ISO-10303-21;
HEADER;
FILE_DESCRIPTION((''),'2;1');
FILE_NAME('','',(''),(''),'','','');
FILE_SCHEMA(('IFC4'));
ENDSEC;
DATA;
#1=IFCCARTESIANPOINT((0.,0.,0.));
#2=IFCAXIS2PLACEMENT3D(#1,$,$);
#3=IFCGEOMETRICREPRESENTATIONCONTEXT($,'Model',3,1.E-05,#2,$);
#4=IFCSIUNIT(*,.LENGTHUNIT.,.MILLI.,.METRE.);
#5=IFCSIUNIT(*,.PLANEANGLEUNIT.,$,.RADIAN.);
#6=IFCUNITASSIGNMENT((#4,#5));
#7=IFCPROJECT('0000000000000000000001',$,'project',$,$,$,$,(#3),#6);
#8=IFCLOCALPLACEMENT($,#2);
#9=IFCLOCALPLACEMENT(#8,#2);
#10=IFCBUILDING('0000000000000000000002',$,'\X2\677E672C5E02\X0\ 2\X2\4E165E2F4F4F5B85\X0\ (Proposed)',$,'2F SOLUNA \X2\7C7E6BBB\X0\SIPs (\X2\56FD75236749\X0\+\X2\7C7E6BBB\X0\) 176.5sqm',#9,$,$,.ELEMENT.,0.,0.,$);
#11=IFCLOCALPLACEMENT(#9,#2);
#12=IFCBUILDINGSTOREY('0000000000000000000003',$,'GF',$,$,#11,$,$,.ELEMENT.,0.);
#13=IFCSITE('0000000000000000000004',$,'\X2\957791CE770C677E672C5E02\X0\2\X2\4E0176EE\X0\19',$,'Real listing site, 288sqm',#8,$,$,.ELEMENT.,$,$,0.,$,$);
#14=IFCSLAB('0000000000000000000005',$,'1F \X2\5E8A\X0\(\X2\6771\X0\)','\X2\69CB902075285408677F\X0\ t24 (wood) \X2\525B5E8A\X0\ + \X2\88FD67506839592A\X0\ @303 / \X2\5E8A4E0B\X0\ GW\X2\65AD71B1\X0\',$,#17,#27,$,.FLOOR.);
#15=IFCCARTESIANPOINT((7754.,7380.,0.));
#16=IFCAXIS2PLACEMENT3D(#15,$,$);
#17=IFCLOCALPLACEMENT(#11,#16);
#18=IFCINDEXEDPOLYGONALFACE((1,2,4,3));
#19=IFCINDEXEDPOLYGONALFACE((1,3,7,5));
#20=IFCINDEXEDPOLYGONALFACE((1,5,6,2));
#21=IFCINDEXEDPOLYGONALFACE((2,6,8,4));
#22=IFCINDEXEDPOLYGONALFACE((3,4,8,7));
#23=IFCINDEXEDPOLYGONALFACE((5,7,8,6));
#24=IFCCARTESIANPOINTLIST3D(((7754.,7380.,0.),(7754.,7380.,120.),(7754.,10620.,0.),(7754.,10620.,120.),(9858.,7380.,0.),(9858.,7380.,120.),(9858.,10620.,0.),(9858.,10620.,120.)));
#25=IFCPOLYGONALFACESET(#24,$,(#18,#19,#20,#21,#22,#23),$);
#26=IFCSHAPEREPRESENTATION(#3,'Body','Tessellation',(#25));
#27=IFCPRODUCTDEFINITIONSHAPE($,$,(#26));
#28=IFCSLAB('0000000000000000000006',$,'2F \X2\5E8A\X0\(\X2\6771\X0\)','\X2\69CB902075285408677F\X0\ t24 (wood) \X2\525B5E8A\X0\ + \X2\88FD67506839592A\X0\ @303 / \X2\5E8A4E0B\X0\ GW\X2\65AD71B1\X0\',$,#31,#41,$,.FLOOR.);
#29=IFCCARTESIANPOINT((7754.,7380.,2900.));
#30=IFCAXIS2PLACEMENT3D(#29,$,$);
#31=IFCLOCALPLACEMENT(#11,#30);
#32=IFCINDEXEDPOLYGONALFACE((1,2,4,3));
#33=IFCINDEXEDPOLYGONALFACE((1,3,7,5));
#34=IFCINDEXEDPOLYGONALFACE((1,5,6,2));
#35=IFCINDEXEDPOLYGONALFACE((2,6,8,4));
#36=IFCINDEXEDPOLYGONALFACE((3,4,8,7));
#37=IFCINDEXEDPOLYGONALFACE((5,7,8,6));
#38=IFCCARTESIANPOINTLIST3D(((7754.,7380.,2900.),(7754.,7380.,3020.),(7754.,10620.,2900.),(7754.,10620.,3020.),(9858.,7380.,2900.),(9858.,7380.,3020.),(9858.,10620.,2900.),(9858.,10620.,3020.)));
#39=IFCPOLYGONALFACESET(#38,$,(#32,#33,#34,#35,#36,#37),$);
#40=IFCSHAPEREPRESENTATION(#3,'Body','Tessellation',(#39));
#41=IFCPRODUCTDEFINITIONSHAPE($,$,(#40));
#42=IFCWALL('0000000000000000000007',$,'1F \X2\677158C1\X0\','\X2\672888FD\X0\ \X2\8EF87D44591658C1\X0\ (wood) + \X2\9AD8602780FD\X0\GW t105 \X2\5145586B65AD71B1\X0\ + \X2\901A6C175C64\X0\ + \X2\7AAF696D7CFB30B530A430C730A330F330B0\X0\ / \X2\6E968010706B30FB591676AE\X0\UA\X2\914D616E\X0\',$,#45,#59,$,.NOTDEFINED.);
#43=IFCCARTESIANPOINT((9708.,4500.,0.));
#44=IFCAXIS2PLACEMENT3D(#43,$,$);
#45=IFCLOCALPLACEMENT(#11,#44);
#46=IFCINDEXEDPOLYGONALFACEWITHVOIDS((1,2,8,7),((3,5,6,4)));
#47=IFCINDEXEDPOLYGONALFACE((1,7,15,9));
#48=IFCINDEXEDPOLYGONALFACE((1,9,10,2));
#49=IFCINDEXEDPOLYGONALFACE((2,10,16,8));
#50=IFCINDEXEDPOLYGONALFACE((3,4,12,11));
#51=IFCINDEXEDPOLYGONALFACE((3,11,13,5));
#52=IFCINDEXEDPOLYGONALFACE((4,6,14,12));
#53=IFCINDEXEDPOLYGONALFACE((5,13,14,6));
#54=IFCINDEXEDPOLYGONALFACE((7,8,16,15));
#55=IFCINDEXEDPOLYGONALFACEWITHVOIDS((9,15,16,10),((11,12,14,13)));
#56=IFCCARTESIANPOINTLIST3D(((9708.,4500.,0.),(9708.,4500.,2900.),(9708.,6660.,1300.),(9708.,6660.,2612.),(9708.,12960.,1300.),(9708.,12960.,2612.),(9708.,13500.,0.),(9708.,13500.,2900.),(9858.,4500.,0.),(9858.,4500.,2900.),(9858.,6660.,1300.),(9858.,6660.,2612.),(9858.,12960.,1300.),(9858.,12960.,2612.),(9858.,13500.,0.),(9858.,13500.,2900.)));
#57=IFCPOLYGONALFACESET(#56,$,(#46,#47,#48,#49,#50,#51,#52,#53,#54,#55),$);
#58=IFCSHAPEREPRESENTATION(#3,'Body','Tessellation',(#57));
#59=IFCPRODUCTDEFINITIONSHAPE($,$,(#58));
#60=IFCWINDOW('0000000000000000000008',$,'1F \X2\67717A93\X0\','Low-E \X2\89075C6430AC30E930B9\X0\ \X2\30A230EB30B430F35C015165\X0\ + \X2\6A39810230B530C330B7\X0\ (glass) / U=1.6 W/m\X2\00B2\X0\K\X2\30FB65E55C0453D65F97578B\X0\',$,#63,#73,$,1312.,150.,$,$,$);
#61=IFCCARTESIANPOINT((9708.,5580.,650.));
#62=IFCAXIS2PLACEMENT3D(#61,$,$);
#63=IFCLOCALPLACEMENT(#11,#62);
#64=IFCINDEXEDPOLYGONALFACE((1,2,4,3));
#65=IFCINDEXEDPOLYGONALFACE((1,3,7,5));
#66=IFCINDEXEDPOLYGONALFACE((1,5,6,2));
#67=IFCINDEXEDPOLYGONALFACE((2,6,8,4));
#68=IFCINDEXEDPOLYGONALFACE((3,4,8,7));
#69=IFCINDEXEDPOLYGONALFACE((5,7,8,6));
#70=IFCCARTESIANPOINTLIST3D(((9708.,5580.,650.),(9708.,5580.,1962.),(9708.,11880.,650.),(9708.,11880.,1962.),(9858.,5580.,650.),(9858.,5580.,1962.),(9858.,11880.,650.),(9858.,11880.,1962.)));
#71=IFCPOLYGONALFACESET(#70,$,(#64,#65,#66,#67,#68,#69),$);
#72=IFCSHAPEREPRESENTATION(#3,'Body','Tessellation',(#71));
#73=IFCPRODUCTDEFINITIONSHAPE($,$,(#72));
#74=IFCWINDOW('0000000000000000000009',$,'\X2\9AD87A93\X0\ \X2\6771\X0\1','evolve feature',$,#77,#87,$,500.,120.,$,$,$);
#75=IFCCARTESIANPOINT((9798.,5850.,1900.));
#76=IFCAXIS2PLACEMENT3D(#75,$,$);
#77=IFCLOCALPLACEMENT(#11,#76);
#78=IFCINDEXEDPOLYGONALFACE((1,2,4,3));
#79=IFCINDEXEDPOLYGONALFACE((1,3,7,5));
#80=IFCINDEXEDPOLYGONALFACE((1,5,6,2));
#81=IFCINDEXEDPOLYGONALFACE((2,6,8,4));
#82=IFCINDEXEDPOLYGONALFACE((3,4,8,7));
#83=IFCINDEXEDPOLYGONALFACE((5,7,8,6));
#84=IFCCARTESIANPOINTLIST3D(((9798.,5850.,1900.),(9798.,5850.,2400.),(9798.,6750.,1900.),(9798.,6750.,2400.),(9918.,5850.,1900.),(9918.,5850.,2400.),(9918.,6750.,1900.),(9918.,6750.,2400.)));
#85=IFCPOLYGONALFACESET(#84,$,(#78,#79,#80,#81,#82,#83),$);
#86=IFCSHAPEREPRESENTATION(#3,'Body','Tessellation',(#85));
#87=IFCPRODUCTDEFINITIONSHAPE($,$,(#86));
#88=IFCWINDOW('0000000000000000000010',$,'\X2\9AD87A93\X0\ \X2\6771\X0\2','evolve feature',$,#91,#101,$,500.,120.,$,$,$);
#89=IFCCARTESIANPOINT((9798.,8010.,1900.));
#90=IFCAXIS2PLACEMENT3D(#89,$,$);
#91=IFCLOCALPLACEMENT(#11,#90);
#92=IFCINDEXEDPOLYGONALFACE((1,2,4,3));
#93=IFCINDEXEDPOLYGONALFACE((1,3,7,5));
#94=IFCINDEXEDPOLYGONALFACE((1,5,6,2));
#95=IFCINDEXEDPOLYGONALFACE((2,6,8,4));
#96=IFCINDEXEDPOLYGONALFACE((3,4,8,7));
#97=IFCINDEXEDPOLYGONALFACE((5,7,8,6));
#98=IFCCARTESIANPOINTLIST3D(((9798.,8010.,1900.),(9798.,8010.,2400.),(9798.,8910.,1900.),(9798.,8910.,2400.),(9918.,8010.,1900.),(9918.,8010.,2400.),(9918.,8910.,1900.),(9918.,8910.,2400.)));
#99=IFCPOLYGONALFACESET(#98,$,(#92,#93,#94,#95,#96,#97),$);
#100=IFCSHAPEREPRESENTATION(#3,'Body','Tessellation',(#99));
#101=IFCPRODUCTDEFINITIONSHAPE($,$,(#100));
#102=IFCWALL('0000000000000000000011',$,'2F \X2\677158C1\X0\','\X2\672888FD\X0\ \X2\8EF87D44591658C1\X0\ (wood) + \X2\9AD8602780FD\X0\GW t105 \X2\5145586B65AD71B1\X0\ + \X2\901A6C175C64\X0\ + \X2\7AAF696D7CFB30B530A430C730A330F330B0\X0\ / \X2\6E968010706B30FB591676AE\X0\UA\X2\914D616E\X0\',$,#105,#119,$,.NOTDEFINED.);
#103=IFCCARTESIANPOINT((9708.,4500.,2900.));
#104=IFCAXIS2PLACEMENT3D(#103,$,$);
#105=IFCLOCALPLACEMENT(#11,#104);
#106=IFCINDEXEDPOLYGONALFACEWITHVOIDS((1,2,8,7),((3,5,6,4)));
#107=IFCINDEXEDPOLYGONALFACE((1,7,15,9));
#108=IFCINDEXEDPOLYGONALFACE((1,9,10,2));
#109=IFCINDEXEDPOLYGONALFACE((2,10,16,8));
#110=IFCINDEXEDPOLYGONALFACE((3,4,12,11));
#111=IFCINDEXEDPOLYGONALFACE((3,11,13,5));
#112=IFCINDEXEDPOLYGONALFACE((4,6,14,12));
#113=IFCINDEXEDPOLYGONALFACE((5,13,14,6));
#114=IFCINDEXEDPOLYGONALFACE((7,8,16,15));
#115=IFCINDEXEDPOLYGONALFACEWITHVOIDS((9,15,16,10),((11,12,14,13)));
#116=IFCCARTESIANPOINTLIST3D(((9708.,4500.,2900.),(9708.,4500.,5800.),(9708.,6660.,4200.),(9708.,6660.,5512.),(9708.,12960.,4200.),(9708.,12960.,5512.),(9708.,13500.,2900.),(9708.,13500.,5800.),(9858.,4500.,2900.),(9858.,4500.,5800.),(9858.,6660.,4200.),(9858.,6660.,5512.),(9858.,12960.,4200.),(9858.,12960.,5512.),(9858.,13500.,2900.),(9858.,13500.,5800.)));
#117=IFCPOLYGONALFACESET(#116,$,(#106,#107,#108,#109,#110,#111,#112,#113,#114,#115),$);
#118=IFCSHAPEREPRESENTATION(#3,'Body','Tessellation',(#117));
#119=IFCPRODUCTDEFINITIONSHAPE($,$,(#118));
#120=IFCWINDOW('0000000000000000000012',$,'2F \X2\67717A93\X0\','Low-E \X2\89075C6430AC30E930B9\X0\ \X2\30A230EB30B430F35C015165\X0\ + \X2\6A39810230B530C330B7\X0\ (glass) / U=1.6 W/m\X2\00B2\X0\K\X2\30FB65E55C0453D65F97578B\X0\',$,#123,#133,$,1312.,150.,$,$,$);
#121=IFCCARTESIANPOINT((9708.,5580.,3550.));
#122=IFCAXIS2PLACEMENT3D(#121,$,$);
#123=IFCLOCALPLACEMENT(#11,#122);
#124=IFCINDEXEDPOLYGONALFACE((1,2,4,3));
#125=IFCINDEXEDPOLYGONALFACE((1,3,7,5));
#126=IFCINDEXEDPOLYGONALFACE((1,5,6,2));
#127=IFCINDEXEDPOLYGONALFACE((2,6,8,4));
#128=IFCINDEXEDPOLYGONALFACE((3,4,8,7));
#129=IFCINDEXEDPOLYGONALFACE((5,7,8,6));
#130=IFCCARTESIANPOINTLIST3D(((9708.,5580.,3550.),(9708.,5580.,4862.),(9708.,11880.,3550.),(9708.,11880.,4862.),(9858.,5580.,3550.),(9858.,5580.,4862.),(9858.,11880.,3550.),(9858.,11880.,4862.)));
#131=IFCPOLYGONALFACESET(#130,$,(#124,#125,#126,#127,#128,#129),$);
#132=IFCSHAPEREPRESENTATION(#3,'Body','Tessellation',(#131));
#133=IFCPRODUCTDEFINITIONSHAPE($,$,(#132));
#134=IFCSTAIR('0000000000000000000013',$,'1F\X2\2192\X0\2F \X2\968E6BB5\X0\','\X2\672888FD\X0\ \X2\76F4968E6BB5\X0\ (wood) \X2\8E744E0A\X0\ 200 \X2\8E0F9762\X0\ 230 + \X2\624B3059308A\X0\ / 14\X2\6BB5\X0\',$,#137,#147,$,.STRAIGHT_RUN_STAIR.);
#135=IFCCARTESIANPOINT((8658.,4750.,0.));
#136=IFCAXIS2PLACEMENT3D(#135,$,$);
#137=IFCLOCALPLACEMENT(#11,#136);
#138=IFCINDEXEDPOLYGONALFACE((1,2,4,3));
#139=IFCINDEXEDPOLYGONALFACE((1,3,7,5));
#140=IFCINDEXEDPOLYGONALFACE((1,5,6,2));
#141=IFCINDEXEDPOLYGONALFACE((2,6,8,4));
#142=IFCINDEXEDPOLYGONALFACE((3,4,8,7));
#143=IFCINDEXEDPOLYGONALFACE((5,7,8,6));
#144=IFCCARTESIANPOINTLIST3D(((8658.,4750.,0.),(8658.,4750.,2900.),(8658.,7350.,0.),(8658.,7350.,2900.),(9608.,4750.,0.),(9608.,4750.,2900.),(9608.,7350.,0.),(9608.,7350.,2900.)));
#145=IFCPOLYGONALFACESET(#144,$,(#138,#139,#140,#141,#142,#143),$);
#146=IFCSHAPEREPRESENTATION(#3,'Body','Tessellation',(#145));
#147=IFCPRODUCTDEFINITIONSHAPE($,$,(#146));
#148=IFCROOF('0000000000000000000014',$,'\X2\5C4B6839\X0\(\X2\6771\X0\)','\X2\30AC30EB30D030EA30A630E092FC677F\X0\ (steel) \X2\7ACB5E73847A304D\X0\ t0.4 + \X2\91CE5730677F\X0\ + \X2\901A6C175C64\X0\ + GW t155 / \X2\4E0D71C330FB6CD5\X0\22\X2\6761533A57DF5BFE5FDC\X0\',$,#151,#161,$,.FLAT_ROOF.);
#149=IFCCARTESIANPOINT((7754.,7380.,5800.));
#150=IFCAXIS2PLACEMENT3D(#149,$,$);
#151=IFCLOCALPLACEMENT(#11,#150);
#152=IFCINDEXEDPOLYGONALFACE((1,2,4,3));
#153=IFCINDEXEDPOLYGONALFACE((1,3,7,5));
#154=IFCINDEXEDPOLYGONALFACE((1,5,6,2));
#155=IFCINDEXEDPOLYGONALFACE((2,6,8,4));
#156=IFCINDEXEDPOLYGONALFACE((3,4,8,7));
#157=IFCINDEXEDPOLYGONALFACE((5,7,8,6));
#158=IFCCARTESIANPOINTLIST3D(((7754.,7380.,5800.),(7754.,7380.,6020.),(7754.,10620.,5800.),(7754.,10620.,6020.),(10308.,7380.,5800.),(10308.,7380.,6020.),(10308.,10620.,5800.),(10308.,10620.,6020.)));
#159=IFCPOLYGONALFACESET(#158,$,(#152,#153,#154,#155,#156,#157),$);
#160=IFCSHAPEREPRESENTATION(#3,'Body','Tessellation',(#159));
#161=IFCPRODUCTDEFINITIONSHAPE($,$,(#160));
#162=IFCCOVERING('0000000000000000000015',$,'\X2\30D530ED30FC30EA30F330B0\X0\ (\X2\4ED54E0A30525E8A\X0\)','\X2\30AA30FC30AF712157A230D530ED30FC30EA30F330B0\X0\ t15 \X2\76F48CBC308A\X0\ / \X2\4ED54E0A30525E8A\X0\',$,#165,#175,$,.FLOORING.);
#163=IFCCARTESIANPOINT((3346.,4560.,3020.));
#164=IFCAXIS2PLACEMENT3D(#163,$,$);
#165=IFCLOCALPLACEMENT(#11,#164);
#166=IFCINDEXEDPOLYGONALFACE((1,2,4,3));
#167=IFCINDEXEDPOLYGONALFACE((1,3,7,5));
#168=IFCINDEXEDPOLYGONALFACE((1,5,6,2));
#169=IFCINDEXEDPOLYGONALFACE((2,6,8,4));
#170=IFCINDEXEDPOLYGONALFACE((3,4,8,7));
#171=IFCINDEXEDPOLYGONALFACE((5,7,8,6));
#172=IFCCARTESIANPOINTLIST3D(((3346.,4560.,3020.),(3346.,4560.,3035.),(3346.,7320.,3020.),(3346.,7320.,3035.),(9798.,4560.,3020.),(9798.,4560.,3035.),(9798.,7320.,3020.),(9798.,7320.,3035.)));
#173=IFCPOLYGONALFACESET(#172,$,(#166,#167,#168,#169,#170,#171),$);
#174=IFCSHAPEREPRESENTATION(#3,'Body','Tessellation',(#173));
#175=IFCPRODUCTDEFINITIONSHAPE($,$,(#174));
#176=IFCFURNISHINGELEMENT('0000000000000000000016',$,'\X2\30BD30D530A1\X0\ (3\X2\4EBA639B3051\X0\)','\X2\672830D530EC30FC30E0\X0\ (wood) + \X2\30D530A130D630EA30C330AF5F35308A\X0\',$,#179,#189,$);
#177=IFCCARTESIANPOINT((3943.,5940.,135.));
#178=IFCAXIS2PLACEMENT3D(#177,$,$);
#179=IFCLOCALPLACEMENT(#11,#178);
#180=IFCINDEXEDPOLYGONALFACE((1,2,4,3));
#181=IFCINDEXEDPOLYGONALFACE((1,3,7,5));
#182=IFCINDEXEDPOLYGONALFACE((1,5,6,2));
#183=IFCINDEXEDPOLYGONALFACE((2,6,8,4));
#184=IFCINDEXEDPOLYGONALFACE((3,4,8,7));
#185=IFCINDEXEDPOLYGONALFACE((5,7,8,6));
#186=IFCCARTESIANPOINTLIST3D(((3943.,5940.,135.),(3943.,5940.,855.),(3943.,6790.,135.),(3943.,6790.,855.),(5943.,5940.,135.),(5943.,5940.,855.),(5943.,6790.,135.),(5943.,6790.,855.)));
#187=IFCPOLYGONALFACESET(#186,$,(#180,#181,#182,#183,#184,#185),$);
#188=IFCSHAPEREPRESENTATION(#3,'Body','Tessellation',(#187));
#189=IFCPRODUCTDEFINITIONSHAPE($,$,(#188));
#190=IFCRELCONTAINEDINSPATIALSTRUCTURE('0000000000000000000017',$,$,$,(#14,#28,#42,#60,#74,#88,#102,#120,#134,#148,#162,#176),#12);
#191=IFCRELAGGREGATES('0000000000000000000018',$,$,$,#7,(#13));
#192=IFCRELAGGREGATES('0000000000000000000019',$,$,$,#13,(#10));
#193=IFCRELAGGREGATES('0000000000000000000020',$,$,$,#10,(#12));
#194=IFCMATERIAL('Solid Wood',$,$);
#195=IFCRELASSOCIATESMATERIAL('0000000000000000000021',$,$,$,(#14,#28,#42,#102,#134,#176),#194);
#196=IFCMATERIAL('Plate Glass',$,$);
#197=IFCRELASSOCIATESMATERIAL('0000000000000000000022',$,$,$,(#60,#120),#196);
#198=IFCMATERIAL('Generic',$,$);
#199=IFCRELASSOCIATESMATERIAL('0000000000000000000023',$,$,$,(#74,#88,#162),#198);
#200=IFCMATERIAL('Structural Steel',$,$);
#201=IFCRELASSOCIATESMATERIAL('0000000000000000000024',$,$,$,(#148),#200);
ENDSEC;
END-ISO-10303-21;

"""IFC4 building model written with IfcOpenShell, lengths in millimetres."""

from ifc_helpers import new_model, si_unit, frame, frame_2d, origin, place, context, project, spatial, rectangle, extrude, material, element, fill, save


model = new_model("IFC4")

# Units and contexts
model_context = context("Model", 3, precision=1e-05, world=origin())
ifc_project = project(units=[si_unit("LENGTHUNIT", "METRE", prefix="MILLI"), si_unit("PLANEANGLEUNIT", "RADIAN")], contexts=[model_context])

# Site, building, storey
site_placement = place(None, origin())
site = spatial("IfcSite", under=ifc_project, at=site_placement, Name="長野県松本市2丁目19", ObjectType="Real listing site, 288sqm", CompositionType="ELEMENT", RefElevation=0.0)
building_placement = place(site_placement, origin())
building = spatial("IfcBuilding", under=site, at=building_placement, Name="松本市 2世帯住宅 (Proposed)", ObjectType="2F SOLUNA 籾殻SIPs (国産杉+籾殻) 176.5sqm", CompositionType="ELEMENT", ElevationOfRefHeight=0.0, ElevationOfTerrain=0.0)
storey_placement = place(building_placement, origin())
storey = spatial("IfcBuildingStorey", under=building, at=storey_placement, Name="GF", CompositionType="ELEMENT", Elevation=0.0)

# Slabs
ifc_material_1 = material(Name="Solid Wood")
slab_1_placement = place(storey_placement, frame((7754.0, 7380.0, 0.0)))
element("IfcSlab", 1, at=slab_1_placement, inside=storey, material=ifc_material_1, Name="1F 床(東)", Description="構造用合板 t24 (wood) 剛床 + 製材根太 @303 / 床下 GW断熱", PredefinedType="FLOOR", context=model_context, shape_type="SweptSolid", body=[
    extrude(rectangle(XDim=2104.0, YDim=3240.0, at=frame_2d((1052.0, 1620.0))), frame((7754.0, 7380.0, 0.0)), (0.0, 0.0, 1.0), 120.0),
])
slab_2_placement = place(storey_placement, frame((7754.0, 7380.0, 2900.0)))
element("IfcSlab", 2, at=slab_2_placement, inside=storey, material=ifc_material_1, Name="2F 床(東)", Description="構造用合板 t24 (wood) 剛床 + 製材根太 @303 / 床下 GW断熱", PredefinedType="FLOOR", context=model_context, shape_type="SweptSolid", body=[
    extrude(rectangle(XDim=2104.0, YDim=3240.0, at=frame_2d((1052.0, 1620.0))), frame((7754.0, 7380.0, 2900.0)), (0.0, 0.0, 1.0), 120.0),
])

# Wall, openings, windows
wall_1_placement = place(storey_placement, frame((9708.0, 4500.0, 0.0)))
wall_1 = element("IfcWall", 3, at=wall_1_placement, inside=storey, material=ifc_material_1, Name="1F 東壁", Description="木製 軸組外壁 (wood) + 高性能GW t105 充填断熱 + 通気層 + 窯業系サイディング / 準耐火・外皮UA配慮", PredefinedType="NOTDEFINED", context=model_context, shape_type="SweptSolid", body=[
    extrude(rectangle(XDim=150.0, YDim=9000.0, at=frame_2d((75.0, 4500.0))), frame((9708.0, 4500.0, 0.0)), (0.0, 0.0, 1.0), 2900.0),
])
opening_1_placement = place(storey_placement, frame((9708.0, 5580.0, 650.0)))
opening_1 = element("IfcOpeningElement", 4, at=opening_1_placement, cuts=wall_1, PredefinedType="NOTDEFINED", context=model_context, shape_type="SweptSolid", body=[
    extrude(rectangle(XDim=150.0, YDim=6300.0, at=frame_2d((75.0, 3150.0))), frame((9708.0, 5580.0, 650.0)), (0.0, 0.0, 1.0), 1312.0),
])
opening_2_placement = place(storey_placement, frame((9798.0, 5850.0, 1900.0)))
opening_2 = element("IfcOpeningElement", 5, at=opening_2_placement, cuts=wall_1, PredefinedType="NOTDEFINED", context=model_context, shape_type="SweptSolid", body=[
    extrude(rectangle(XDim=120.0, YDim=900.0, at=frame_2d((60.0, 450.0))), frame((9798.0, 5850.0, 1900.0)), (0.0, 0.0, 1.0), 500.0),
])
opening_3_placement = place(storey_placement, frame((9798.0, 8010.0, 1900.0)))
opening_3 = element("IfcOpeningElement", 6, at=opening_3_placement, cuts=wall_1, PredefinedType="NOTDEFINED", context=model_context, shape_type="SweptSolid", body=[
    extrude(rectangle(XDim=120.0, YDim=900.0, at=frame_2d((60.0, 450.0))), frame((9798.0, 8010.0, 1900.0)), (0.0, 0.0, 1.0), 500.0),
])
ifc_material_2 = material(Name="Plate Glass")
window_1_placement = place(storey_placement, frame((9708.0, 5580.0, 650.0)))
window_1 = element("IfcWindow", 7, at=window_1_placement, inside=storey, material=ifc_material_2, Name="1F 東窓", Description="Low-E 複層ガラス アルゴン封入 + 樹脂サッシ (glass) / U=1.6 W/m²K・日射取得型", OverallHeight=1312.0, OverallWidth=150.0, context=model_context, shape_type="SweptSolid", body=[
    extrude(rectangle(XDim=150.0, YDim=6300.0, at=frame_2d((75.0, 3150.0))), frame((9708.0, 5580.0, 650.0)), (0.0, 0.0, 1.0), 1312.0),
])
fill(opening_1, window_1)
ifc_material_3 = material(Name="Generic")
window_2_placement = place(storey_placement, frame((9798.0, 5850.0, 1900.0)))
window_2 = element("IfcWindow", 8, at=window_2_placement, inside=storey, material=ifc_material_3, Name="高窓 東1", Description="evolve feature", OverallHeight=500.0, OverallWidth=120.0, context=model_context, shape_type="SweptSolid", body=[
    extrude(rectangle(XDim=120.0, YDim=900.0, at=frame_2d((60.0, 450.0))), frame((9798.0, 5850.0, 1900.0)), (0.0, 0.0, 1.0), 500.0),
])
fill(opening_2, window_2)
window_3_placement = place(storey_placement, frame((9798.0, 8010.0, 1900.0)))
window_3 = element("IfcWindow", 9, at=window_3_placement, inside=storey, material=ifc_material_3, Name="高窓 東2", Description="evolve feature", OverallHeight=500.0, OverallWidth=120.0, context=model_context, shape_type="SweptSolid", body=[
    extrude(rectangle(XDim=120.0, YDim=900.0, at=frame_2d((60.0, 450.0))), frame((9798.0, 8010.0, 1900.0)), (0.0, 0.0, 1.0), 500.0),
])
fill(opening_3, window_3)

# Wall, opening, window
wall_2_placement = place(storey_placement, frame((9708.0, 4500.0, 2900.0)))
wall_2 = element("IfcWall", 10, at=wall_2_placement, inside=storey, material=ifc_material_1, Name="2F 東壁", Description="木製 軸組外壁 (wood) + 高性能GW t105 充填断熱 + 通気層 + 窯業系サイディング / 準耐火・外皮UA配慮", PredefinedType="NOTDEFINED", context=model_context, shape_type="SweptSolid", body=[
    extrude(rectangle(XDim=150.0, YDim=9000.0, at=frame_2d((75.0, 4500.0))), frame((9708.0, 4500.0, 2900.0)), (0.0, 0.0, 1.0), 2900.0),
])
opening_4_placement = place(storey_placement, frame((9708.0, 5580.0, 3550.0)))
opening_4 = element("IfcOpeningElement", 11, at=opening_4_placement, cuts=wall_2, PredefinedType="NOTDEFINED", context=model_context, shape_type="SweptSolid", body=[
    extrude(rectangle(XDim=150.0, YDim=6300.0, at=frame_2d((75.0, 3150.0))), frame((9708.0, 5580.0, 3550.0)), (0.0, 0.0, 1.0), 1312.0),
])
window_4_placement = place(storey_placement, frame((9708.0, 5580.0, 3550.0)))
window_4 = element("IfcWindow", 12, at=window_4_placement, inside=storey, material=ifc_material_2, Name="2F 東窓", Description="Low-E 複層ガラス アルゴン封入 + 樹脂サッシ (glass) / U=1.6 W/m²K・日射取得型", OverallHeight=1312.0, OverallWidth=150.0, context=model_context, shape_type="SweptSolid", body=[
    extrude(rectangle(XDim=150.0, YDim=6300.0, at=frame_2d((75.0, 3150.0))), frame((9708.0, 5580.0, 3550.0)), (0.0, 0.0, 1.0), 1312.0),
])
fill(opening_4, window_4)

# Stair
stair_placement = place(storey_placement, frame((8658.0, 4750.0, 0.0)))
element("IfcStair", 13, at=stair_placement, inside=storey, material=ifc_material_1, Name="1F→2F 階段", Description="木製 直階段 (wood) 蹴上 200 踏面 230 + 手すり / 14段", PredefinedType="STRAIGHT_RUN_STAIR", context=model_context, shape_type="SweptSolid", body=[
    extrude(rectangle(XDim=950.0, YDim=2600.0, at=frame_2d((475.0, 1300.0))), frame((8658.0, 4750.0, 0.0)), (0.0, 0.0, 1.0), 2900.0),
])

# Roof
ifc_material_4 = material(Name="Structural Steel")
roof_placement = place(storey_placement, frame((7754.0, 7380.0, 5800.0)))
element("IfcRoof", 14, at=roof_placement, inside=storey, material=ifc_material_4, Name="屋根(東)", Description="ガルバリウム鋼板 (steel) 立平葺き t0.4 + 野地板 + 通気層 + GW t155 / 不燃・法22条区域対応", PredefinedType="FLAT_ROOF", context=model_context, shape_type="SweptSolid", body=[
    extrude(rectangle(XDim=2554.0, YDim=3240.0, at=frame_2d((1277.0, 1620.0))), frame((7754.0, 7380.0, 5800.0)), (0.0, 0.0, 1.0), 220.0),
])

# Covering
covering_placement = place(storey_placement, frame((3346.0, 4560.0, 3020.0)))
element("IfcCovering", 15, at=covering_placement, inside=storey, material=ifc_material_3, Name="フローリング (仕上げ床)", Description="オーク無垢フローリング t15 直貼り / 仕上げ床", PredefinedType="FLOORING", context=model_context, shape_type="SweptSolid", body=[
    extrude(rectangle(XDim=6452.0, YDim=2760.0, at=frame_2d((3226.0, 1380.0))), frame((3346.0, 4560.0, 3020.0)), (0.0, 0.0, 1.0), 15.0),
])

# Furnishing element
furnishing_1_placement = place(storey_placement, frame((3943.0, 5940.0, 135.0)))
element("IfcFurnishingElement", 16, at=furnishing_1_placement, inside=storey, material=ifc_material_1, Name="ソファ (3人掛け)", Description="木フレーム (wood) + ファブリック張り", context=model_context, shape_type="SweptSolid", body=[
    extrude(rectangle(XDim=2000.0, YDim=850.0, at=frame_2d((1000.0, 425.0))), frame((3943.0, 5940.0, 135.0)), (0.0, 0.0, 1.0), 720.0),
])

save(model, "model.ifc")
